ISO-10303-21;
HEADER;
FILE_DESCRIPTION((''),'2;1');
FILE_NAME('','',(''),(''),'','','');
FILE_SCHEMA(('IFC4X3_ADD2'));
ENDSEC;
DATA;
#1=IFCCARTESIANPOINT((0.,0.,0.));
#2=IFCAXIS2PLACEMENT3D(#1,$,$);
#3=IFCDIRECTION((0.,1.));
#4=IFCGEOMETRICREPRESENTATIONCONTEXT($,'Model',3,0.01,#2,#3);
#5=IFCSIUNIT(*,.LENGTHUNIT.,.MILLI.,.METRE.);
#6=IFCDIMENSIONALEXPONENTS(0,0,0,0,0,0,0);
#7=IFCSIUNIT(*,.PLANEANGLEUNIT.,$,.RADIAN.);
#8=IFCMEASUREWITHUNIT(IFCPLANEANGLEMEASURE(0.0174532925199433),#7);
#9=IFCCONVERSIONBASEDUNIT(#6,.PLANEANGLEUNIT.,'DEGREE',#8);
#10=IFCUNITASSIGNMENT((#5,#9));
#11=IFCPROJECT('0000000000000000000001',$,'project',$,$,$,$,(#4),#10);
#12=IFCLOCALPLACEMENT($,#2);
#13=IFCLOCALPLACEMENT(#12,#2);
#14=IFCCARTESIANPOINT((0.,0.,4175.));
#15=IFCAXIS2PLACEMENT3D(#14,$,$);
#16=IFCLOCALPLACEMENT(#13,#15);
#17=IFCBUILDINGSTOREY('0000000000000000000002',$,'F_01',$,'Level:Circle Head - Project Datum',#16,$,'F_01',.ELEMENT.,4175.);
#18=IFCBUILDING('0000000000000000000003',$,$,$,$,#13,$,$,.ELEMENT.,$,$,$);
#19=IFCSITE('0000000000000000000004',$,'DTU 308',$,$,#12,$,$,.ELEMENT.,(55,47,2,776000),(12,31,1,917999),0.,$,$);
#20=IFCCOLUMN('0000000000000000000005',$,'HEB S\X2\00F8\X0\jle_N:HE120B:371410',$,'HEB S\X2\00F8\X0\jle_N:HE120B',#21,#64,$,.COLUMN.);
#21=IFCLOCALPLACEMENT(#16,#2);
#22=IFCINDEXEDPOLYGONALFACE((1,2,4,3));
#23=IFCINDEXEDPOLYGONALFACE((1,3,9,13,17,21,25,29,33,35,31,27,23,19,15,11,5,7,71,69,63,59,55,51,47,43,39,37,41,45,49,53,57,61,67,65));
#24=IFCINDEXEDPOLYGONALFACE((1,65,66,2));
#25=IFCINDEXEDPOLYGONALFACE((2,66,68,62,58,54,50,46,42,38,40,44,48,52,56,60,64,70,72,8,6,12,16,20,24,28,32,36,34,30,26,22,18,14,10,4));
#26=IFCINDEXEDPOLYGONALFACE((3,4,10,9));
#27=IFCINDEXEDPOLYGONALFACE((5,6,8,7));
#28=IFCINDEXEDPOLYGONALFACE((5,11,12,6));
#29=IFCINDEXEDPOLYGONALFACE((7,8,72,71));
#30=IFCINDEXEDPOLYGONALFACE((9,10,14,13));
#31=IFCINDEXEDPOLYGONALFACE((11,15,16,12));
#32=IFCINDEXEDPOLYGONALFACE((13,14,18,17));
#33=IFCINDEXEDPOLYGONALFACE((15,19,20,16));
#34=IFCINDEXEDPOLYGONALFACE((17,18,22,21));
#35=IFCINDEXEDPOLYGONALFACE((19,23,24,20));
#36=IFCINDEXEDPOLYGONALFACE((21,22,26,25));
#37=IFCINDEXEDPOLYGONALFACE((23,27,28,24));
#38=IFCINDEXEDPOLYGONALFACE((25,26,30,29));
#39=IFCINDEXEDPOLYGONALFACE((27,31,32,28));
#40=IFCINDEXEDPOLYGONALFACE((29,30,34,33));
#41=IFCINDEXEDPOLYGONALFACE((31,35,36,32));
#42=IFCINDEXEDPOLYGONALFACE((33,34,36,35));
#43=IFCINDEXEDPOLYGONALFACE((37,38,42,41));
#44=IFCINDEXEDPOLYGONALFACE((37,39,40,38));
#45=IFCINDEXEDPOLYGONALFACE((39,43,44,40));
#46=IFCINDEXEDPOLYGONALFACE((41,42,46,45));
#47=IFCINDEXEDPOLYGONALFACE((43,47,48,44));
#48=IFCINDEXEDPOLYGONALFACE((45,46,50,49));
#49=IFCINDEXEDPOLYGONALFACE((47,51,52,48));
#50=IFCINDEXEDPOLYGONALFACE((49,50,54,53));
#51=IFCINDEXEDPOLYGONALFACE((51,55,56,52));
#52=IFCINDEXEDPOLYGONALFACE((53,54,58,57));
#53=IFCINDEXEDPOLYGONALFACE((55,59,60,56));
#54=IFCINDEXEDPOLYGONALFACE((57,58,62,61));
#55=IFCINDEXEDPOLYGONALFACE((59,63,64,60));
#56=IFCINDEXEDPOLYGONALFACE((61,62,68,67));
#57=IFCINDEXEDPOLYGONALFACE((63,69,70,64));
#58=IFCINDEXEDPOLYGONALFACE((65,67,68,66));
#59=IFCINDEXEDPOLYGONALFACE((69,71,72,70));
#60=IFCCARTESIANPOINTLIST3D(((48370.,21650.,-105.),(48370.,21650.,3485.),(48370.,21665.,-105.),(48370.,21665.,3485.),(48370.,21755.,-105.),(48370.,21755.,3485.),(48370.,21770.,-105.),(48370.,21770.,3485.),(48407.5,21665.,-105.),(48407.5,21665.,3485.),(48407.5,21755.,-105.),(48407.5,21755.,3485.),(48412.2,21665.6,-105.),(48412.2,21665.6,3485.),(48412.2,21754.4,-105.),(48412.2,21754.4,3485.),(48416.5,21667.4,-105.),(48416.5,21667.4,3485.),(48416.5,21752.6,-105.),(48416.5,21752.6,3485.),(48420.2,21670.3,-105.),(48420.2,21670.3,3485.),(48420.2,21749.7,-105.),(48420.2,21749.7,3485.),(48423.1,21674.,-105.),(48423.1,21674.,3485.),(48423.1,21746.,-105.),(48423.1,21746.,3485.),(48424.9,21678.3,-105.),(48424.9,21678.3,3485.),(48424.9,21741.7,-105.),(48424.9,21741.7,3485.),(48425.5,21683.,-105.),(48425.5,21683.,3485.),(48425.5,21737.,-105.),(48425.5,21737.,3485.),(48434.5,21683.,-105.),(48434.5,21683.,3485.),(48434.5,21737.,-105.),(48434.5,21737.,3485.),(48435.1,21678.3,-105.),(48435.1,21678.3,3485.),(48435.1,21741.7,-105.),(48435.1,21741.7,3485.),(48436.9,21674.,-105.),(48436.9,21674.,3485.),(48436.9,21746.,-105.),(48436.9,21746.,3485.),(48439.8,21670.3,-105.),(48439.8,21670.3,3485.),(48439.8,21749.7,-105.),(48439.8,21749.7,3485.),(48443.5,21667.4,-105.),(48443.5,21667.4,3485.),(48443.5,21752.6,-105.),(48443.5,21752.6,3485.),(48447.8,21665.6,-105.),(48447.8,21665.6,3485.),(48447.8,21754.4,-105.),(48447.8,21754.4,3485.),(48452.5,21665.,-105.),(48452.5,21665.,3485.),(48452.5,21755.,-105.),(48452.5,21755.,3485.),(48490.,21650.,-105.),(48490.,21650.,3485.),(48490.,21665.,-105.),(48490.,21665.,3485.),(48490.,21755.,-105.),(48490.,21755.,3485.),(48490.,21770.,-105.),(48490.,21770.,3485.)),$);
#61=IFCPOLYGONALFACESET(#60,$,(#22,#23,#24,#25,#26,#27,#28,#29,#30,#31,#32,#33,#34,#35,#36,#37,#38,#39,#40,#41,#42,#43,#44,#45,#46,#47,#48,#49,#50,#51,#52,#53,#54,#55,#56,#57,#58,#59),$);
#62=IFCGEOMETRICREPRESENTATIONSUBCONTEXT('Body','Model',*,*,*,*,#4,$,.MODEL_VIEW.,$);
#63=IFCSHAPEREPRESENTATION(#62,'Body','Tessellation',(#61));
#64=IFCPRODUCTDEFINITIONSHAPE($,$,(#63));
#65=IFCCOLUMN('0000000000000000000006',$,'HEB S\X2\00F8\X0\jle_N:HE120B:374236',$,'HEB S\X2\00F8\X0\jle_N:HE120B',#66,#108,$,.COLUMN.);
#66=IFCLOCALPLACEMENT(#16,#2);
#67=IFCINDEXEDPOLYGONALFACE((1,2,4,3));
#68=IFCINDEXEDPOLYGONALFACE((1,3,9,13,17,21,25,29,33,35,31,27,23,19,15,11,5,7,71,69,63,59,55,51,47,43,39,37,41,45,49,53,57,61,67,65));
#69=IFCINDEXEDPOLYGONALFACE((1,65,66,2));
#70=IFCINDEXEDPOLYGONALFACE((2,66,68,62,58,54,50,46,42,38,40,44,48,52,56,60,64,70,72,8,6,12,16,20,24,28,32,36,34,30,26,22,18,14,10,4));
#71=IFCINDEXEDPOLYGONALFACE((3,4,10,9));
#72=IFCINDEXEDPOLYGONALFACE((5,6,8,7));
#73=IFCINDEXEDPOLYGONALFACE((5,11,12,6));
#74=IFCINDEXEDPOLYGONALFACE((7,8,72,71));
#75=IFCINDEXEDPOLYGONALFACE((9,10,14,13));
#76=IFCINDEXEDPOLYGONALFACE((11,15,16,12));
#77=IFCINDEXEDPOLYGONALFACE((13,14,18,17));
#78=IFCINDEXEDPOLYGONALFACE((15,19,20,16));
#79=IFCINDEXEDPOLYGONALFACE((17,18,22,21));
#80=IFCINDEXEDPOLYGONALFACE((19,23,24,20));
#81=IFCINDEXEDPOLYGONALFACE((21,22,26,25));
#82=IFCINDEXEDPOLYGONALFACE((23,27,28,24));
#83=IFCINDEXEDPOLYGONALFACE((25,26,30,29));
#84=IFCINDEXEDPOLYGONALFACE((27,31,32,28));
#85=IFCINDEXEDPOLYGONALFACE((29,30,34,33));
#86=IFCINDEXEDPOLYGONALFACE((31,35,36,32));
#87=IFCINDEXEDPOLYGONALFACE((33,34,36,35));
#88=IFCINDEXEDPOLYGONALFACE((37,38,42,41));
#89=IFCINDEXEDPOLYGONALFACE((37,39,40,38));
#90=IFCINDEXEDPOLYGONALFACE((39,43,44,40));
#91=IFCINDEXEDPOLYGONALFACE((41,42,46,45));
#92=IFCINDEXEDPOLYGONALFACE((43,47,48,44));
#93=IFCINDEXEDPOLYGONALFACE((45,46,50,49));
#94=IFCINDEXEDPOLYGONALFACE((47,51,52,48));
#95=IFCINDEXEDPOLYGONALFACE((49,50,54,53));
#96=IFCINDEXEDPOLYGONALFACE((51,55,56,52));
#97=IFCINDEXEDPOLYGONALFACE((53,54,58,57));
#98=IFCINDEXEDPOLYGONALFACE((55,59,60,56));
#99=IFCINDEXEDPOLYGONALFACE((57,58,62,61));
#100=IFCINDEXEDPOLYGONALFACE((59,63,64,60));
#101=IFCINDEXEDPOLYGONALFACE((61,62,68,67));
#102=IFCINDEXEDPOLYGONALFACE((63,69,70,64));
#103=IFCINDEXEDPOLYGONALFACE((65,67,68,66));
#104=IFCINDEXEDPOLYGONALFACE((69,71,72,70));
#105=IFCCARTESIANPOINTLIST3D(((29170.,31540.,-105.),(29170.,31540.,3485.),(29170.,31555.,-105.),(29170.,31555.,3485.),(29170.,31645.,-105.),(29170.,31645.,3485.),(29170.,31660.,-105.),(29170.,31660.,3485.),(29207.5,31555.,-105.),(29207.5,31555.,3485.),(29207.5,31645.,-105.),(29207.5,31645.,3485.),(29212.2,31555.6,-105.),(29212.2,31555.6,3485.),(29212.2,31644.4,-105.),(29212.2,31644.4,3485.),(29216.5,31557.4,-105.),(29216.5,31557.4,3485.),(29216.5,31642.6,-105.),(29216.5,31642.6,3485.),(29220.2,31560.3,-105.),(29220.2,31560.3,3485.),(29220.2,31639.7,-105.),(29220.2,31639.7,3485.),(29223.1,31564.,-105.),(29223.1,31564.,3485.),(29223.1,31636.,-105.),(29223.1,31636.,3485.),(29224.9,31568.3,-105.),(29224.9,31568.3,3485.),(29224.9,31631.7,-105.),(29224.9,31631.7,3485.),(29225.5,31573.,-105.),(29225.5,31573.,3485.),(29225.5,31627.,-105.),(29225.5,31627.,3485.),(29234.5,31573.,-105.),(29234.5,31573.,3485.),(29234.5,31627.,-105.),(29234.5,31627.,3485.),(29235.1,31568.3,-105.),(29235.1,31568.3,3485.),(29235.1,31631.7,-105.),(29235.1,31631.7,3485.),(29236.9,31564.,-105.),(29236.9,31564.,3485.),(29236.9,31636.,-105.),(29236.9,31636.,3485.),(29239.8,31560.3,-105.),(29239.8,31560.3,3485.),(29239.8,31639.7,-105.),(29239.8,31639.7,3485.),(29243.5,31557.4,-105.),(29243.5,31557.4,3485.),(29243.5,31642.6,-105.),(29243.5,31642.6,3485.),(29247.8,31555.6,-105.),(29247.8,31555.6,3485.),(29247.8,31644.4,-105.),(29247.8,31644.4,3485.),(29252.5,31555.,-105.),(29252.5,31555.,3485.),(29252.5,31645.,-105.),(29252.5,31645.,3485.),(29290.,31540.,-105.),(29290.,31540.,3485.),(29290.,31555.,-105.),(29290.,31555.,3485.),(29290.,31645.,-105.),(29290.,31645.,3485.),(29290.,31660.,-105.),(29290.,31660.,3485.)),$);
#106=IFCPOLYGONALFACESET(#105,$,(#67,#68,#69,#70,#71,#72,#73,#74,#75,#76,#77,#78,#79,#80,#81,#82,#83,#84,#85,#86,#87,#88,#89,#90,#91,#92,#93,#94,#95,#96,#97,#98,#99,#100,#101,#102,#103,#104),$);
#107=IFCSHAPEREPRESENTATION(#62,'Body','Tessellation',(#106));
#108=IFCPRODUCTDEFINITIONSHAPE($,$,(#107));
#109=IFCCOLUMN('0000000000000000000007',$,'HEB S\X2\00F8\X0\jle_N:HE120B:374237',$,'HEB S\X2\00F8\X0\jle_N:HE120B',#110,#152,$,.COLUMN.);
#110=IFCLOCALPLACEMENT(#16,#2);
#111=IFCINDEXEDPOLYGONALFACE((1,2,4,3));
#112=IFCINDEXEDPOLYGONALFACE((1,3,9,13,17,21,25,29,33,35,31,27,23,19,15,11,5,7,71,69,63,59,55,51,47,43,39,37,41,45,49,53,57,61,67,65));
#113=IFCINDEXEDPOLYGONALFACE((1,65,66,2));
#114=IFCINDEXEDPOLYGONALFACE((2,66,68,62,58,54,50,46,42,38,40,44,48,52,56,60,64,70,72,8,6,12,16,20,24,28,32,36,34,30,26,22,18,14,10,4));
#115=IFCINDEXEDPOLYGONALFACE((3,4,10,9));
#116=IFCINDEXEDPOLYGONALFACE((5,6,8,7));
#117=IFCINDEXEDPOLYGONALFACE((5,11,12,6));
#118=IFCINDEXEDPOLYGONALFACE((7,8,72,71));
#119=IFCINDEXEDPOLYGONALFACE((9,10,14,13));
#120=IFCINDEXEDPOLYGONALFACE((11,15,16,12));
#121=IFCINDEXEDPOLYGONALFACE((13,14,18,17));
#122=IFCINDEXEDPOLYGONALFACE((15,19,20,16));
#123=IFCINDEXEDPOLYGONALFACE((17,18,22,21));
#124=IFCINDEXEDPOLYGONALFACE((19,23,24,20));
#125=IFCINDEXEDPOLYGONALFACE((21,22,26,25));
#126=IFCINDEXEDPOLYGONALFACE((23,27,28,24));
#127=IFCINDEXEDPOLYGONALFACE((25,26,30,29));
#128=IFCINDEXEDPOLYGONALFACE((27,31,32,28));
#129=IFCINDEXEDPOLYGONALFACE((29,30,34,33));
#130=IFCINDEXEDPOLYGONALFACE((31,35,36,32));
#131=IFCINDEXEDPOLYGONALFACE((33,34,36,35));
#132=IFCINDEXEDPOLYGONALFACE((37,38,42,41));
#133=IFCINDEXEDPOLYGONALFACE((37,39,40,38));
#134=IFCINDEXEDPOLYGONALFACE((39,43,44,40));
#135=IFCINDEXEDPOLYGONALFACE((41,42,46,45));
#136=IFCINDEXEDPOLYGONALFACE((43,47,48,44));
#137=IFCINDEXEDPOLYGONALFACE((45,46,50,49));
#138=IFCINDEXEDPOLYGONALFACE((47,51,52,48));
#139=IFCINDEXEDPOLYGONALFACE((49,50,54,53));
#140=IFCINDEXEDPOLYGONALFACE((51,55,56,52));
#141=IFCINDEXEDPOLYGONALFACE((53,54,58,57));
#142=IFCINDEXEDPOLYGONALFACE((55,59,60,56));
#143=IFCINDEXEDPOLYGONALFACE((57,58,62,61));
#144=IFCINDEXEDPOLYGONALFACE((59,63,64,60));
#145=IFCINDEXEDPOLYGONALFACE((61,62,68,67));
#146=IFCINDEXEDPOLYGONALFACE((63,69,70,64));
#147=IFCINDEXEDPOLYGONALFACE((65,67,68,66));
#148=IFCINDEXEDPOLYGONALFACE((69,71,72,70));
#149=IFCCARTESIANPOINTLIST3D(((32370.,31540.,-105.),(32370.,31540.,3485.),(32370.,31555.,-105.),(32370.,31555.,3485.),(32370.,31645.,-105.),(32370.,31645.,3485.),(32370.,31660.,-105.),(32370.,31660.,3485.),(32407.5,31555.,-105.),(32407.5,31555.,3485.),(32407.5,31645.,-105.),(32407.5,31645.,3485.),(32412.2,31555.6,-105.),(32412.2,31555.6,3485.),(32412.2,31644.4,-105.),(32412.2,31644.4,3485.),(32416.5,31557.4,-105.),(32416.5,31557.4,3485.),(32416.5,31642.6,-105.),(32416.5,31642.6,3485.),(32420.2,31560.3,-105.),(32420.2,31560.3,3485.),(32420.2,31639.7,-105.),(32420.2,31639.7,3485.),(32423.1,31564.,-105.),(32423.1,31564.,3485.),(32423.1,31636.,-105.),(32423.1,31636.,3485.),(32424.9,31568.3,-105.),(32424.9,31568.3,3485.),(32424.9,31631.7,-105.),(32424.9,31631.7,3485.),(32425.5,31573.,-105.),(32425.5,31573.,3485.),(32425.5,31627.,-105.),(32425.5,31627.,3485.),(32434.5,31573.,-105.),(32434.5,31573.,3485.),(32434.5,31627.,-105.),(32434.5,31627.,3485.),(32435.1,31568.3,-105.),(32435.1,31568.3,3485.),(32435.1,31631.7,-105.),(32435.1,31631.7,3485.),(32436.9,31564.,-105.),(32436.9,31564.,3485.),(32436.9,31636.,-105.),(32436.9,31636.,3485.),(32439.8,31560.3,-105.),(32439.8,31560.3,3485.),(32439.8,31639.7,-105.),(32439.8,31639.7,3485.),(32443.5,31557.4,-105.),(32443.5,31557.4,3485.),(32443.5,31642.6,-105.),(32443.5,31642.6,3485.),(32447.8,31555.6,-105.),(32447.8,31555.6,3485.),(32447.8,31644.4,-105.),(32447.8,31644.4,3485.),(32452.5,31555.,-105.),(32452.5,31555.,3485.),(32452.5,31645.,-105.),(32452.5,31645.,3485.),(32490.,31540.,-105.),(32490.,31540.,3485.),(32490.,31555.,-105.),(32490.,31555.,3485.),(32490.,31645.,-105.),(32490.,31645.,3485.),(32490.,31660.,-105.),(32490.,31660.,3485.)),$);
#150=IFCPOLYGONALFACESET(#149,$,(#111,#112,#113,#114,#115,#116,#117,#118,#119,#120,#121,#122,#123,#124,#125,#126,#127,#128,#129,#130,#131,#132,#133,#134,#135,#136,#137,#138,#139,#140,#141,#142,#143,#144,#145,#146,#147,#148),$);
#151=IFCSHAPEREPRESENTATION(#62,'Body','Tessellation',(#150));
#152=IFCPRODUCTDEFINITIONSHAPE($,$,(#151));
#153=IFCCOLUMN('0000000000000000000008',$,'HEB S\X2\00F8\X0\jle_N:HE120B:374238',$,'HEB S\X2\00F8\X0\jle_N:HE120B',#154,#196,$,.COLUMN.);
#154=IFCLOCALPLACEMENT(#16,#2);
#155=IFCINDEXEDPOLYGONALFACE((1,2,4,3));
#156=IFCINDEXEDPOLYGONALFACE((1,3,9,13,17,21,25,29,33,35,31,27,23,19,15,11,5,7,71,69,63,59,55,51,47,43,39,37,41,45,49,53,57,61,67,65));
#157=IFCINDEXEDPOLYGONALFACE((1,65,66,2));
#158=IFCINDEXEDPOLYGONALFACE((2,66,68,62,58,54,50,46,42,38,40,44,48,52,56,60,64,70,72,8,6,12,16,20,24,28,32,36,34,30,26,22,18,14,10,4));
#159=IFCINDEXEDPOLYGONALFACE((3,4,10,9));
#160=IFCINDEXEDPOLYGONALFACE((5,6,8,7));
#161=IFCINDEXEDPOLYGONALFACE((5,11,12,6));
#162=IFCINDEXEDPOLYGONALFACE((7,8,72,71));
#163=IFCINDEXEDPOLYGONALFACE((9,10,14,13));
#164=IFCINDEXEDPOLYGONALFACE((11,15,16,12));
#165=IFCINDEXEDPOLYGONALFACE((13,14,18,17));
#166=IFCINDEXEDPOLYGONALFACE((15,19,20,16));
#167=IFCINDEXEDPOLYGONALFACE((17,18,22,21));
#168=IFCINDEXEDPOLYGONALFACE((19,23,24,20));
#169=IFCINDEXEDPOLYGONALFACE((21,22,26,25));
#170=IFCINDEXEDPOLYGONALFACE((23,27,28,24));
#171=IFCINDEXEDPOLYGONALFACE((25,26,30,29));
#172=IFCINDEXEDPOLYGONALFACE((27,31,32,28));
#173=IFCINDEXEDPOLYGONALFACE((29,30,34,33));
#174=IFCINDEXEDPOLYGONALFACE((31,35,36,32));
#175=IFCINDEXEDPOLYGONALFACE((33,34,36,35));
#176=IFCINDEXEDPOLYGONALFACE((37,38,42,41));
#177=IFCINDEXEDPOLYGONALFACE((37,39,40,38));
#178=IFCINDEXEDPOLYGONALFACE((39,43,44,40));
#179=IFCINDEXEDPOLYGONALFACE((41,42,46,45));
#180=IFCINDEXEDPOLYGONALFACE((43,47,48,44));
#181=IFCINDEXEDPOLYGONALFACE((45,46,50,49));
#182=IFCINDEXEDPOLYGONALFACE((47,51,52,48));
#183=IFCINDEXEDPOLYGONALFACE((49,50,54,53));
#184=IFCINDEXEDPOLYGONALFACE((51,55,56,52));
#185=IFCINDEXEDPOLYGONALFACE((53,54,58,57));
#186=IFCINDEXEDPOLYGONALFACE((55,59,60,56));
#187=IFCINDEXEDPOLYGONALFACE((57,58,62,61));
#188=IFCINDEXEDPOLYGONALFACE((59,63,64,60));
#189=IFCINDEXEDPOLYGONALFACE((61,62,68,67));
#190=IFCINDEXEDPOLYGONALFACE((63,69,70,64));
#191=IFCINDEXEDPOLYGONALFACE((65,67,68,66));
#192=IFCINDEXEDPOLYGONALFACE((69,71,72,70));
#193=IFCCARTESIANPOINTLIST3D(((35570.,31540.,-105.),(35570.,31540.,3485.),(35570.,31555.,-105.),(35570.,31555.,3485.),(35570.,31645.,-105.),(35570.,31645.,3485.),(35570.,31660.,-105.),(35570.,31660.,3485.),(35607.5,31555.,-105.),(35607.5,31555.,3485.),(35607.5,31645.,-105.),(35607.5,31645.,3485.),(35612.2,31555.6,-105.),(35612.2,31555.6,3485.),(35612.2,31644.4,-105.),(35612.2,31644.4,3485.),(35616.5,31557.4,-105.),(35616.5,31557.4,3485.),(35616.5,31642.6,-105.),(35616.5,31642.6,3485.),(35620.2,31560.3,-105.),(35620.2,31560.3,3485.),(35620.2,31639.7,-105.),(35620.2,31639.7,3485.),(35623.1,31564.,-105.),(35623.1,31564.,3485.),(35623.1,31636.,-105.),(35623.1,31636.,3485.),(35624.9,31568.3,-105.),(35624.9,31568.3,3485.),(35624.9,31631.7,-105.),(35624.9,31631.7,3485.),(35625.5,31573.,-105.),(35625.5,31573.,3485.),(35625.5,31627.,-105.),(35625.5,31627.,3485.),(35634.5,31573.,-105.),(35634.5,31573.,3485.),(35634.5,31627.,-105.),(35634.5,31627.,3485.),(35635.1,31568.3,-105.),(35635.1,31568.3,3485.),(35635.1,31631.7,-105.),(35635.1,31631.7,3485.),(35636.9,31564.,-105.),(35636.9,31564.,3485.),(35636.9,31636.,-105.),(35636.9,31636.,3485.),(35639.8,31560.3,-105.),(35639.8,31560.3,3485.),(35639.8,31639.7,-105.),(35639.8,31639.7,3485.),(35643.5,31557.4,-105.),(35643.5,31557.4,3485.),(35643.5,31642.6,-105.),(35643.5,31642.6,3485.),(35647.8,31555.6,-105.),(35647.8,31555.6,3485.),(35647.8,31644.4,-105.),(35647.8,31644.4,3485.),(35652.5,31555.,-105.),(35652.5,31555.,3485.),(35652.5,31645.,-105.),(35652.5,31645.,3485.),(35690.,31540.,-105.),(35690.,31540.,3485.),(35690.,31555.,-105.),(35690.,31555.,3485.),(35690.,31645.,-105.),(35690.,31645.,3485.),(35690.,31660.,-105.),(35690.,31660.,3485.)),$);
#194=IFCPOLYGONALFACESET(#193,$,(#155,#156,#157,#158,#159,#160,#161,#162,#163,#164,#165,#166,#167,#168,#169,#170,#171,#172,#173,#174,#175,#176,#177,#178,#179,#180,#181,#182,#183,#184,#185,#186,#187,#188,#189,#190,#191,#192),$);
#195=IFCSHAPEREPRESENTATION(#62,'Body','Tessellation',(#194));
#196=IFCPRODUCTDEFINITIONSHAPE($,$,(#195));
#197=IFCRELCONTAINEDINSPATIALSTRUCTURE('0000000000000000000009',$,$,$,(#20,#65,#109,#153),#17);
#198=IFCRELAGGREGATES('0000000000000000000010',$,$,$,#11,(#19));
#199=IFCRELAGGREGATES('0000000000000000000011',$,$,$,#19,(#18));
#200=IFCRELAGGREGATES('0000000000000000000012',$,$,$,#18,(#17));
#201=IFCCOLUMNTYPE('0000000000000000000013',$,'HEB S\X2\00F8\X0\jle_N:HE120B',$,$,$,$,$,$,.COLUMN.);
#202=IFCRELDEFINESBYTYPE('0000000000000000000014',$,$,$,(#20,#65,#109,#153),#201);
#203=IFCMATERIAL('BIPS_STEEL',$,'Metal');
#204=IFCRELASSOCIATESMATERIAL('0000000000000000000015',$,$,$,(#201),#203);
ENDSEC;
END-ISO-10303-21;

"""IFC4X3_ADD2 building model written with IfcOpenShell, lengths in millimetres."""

from ifc_helpers import new_model, entity, si_unit, converted_unit, direction, frame, frame_2d, origin, place, context, subcontext, project, spatial, i_section, extrude, source, transform, mapped, material, material_profile, profile_set, type_object, type_shapes, element, save


model = new_model("IFC4X3_ADD2")

# Units and contexts
model_context = context("Model", 3, precision=0.01, world=origin(), true_north=direction((0.0, 1.0)))
body_context = subcontext(model_context, "Body", "Model", "MODEL_VIEW")
ifc_project = project(units=[si_unit("LENGTHUNIT", "METRE", prefix="MILLI"), converted_unit("PLANEANGLEUNIT", "DEGREE", entity("IfcPlaneAngleMeasure", 0.0174532925199433), si_unit("PLANEANGLEUNIT", "RADIAN"), dimensions=[0, 0, 0, 0, 0, 0, 0])], contexts=[model_context])

# Site, building, storey
site_placement = place(None, origin())
site = spatial("IfcSite", under=ifc_project, at=site_placement, Name="DTU 308", CompositionType="ELEMENT", RefLatitude=(55, 47, 2, 776000), RefLongitude=(12, 31, 1, 917999), RefElevation=0.0)
building_placement = place(site_placement, origin())
building = spatial("IfcBuilding", under=site, at=building_placement, CompositionType="ELEMENT")
storey_placement = place(building_placement, frame((0.0, 0.0, 4175.0)))
storey = spatial("IfcBuildingStorey", under=building, at=storey_placement, Name="F_01", ObjectType="Level:Circle Head - Project Datum", LongName="F_01", CompositionType="ELEMENT", Elevation=4175.0)

# Columns
ifc_material_1 = material(Name="BIPS_STEEL", Category="Metal")
ifc_material_profile_1 = material_profile(ifc_material_1, i_section(OverallWidth=120.0, OverallDepth=120.0, WebThickness=9.0, FlangeThickness=15.0, FilletRadius=18.0, at=frame_2d((0.0, 0.0), x_axis=(1.0, 0.0))), Name="HE120B")
ifc_profile_set_1 = profile_set([ifc_material_profile_1], Name="HE120B")
column_type_1 = type_object("IfcColumnType", Name="HEB Søjle_N:HE120B", PredefinedType="COLUMN", material=ifc_profile_set_1)
shared_shape_1 = source(origin(), body_context, "Body", "SweptSolid", [
    extrude(i_section(OverallWidth=120.0, OverallDepth=120.0, WebThickness=9.0, FlangeThickness=15.0, FilletRadius=18.0, at=frame_2d((0.0, 0.0), x_axis=(1.0, 0.0))), frame((0.0, 0.0, 4070.0), z_axis=(0.0, 0.0, 1.0), x_axis=(-1.0, 0.0, 0.0)), (0.0, 0.0, 1.0), 3590.0),
])
type_shapes(column_type_1, [shared_shape_1])
for number, where, name in (
    (1, (48430.0, 21710.0, -4175.0), "HEB Søjle_N:HE120B:371410"),
    (2, (29230.0, 31600.0, -4175.0), "HEB Søjle_N:HE120B:374236"),
    (3, (32430.0, 31600.0, -4175.0), "HEB Søjle_N:HE120B:374237"),
    (4, (35630.0, 31600.0, -4175.0), "HEB Søjle_N:HE120B:374238"),
):
    element("IfcColumn", number, at=place(storey_placement, frame(where)), inside=storey, type_object=column_type_1, Name=name, ObjectType="HEB Søjle_N:HE120B", PredefinedType="COLUMN", context=body_context, shape_type="MappedRepresentation", body=[
        mapped(shared_shape_1, transform((0.0, 0.0, 0.0), scale=1.0)),
    ])

save(model, "model.ifc")
